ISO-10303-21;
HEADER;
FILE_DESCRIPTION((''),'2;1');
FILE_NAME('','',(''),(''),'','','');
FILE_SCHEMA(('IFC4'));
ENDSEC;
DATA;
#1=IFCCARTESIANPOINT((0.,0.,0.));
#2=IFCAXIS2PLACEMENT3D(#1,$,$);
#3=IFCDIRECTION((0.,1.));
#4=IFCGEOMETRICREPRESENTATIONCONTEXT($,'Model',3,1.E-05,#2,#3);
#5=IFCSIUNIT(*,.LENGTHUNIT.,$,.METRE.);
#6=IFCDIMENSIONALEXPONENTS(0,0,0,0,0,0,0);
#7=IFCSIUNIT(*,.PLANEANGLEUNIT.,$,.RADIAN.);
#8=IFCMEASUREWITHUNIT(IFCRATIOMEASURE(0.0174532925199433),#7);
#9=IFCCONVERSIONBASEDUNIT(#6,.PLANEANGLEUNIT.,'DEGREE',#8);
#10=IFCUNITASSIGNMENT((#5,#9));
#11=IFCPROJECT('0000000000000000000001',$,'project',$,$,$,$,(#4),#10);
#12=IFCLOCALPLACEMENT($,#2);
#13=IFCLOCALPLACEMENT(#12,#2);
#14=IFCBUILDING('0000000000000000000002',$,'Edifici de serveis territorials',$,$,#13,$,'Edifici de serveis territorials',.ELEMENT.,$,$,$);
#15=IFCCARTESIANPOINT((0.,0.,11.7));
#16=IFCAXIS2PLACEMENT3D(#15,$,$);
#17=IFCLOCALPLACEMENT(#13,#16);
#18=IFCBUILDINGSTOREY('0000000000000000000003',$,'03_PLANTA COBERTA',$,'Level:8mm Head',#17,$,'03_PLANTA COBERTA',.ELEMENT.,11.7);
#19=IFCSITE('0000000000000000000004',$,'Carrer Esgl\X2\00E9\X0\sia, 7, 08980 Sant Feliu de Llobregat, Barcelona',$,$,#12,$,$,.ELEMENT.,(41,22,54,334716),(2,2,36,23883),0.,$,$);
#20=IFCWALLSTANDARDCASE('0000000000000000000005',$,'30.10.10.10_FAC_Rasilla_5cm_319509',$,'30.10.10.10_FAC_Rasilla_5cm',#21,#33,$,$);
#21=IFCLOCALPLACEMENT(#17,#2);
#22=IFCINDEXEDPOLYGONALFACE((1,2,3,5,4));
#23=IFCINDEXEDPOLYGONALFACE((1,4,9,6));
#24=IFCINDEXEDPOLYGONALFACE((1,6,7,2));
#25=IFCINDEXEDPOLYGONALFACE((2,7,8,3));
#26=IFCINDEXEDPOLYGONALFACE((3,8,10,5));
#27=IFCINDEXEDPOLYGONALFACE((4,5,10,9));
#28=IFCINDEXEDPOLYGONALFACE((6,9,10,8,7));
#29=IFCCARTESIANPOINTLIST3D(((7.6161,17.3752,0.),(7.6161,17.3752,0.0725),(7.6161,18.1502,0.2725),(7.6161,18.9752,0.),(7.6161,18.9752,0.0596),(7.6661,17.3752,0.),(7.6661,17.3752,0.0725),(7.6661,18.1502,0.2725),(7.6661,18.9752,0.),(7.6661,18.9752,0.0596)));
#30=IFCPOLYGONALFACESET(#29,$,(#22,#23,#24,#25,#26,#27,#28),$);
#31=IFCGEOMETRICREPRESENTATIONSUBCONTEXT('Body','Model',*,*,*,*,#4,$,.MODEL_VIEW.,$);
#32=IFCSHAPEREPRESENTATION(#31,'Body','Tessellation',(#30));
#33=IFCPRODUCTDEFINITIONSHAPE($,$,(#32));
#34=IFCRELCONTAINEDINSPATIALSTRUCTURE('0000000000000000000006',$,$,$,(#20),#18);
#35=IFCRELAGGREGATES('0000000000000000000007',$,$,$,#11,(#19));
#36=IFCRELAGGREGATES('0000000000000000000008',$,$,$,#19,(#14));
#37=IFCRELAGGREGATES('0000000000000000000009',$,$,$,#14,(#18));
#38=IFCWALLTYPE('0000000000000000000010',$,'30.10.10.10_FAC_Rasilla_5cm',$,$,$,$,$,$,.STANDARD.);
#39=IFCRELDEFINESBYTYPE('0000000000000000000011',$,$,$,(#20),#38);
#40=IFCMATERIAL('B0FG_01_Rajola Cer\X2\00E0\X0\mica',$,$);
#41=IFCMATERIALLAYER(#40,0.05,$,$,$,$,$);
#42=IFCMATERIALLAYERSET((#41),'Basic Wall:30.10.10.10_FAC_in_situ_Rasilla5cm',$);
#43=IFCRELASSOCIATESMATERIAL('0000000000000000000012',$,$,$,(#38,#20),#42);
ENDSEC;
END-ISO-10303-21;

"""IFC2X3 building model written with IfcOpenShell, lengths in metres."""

from ifc_helpers import new_model, entity, si_unit, converted_unit, direction, frame, frame_2d, origin, place, context, subcontext, project, spatial, polyline, rectangle, extrude, clip, bounded_halfspace, material, layer, layer_set, layer_usage, type_object, element, save


model = new_model("IFC2X3")

# Units and contexts
model_context = context("Model", 3, precision=1e-05, world=origin(), true_north=direction((0.0, 1.0)))
body_context = subcontext(model_context, "Body", "Model", "MODEL_VIEW")
ifc_project = project(units=[si_unit("LENGTHUNIT", "METRE"), converted_unit("PLANEANGLEUNIT", "DEGREE", entity("IfcRatioMeasure", 0.0174532925199433), si_unit("PLANEANGLEUNIT", "RADIAN"), dimensions=[0, 0, 0, 0, 0, 0, 0])], contexts=[model_context])

# Site, building, storey
site_placement = place(None, origin())
site = spatial("IfcSite", under=ifc_project, at=site_placement, Name="Carrer Església, 7, 08980 Sant Feliu de Llobregat, Barcelona", CompositionType="ELEMENT", RefLatitude=(41, 22, 54, 334716), RefLongitude=(2, 2, 36, 23883), RefElevation=0.0)
building_placement = place(site_placement, origin())
building = spatial("IfcBuilding", under=site, at=building_placement, Name="Edifici de serveis territorials", LongName="Edifici de serveis territorials", CompositionType="ELEMENT")
storey_placement = place(building_placement, frame((0.0, 0.0, 11.7)))
storey = spatial("IfcBuildingStorey", under=building, at=storey_placement, Name="03_PLANTA COBERTA", ObjectType="Level:8mm Head", LongName="03_PLANTA COBERTA", CompositionType="ELEMENT", Elevation=11.7)

# Wall
ifc_material_1 = material(Name="B0FG_01_Rajola Ceràmica")
ifc_layer_1 = layer(ifc_material_1, 0.05)
ifc_layer_set_1 = layer_set([ifc_layer_1], Name="Basic Wall:30.10.10.10_FAC_in_situ_Rasilla5cm")
wall_type_1 = type_object("IfcWallType", Name="30.10.10.10_FAC_Rasilla_5cm", PredefinedType="STANDARD", material=ifc_layer_set_1)
ifc_layer_usage_1 = layer_usage(ifc_layer_set_1, "AXIS2", "NEGATIVE", 0.025)
wall_1_placement = place(storey_placement, frame((7.6411, 18.9752, 0.0), z_axis=(0.0, 0.0, 1.0), x_axis=(0.0, -1.0, 0.0)))
element("IfcWallStandardCase", 1, at=wall_1_placement, inside=storey, type_object=wall_type_1, material=ifc_layer_usage_1, Name="30.10.10.10_FAC_Rasilla_5cm_319509", ObjectType="30.10.10.10_FAC_Rasilla_5cm", context=body_context, shape_type="Clipping", body=[
    clip(clip(extrude(rectangle(XDim=1.6, YDim=0.05, at=frame_2d((0.8, 0.0), x_axis=(-1.0, 0.0))), origin(), (0.0, 0.0, 1.0), 0.2725), bounded_halfspace(frame((0.0, -0.025, 0.0596), z_axis=(0.249878, 0.0, -0.968277), x_axis=(0.0, 1.0, 0.0)), True, frame((0.0, -0.025, 0.0596)), polyline([(0.0, 0.0), (0.05, 0.0), (0.825, 0.0), (0.825, 0.05), (0.0, 0.05), (0.0, 0.0)]))), bounded_halfspace(frame((0.825, -0.025, 0.2725), z_axis=(-0.249878, 0.0, -0.968277), x_axis=(0.0, 1.0, 0.0)), True, frame((0.825, -0.025, 0.2725)), polyline([(0.0, 0.0), (0.775, 0.0), (0.775, 0.05), (0.0, 0.05), (0.0, 0.0)]))),
])

save(model, "model.ifc")
